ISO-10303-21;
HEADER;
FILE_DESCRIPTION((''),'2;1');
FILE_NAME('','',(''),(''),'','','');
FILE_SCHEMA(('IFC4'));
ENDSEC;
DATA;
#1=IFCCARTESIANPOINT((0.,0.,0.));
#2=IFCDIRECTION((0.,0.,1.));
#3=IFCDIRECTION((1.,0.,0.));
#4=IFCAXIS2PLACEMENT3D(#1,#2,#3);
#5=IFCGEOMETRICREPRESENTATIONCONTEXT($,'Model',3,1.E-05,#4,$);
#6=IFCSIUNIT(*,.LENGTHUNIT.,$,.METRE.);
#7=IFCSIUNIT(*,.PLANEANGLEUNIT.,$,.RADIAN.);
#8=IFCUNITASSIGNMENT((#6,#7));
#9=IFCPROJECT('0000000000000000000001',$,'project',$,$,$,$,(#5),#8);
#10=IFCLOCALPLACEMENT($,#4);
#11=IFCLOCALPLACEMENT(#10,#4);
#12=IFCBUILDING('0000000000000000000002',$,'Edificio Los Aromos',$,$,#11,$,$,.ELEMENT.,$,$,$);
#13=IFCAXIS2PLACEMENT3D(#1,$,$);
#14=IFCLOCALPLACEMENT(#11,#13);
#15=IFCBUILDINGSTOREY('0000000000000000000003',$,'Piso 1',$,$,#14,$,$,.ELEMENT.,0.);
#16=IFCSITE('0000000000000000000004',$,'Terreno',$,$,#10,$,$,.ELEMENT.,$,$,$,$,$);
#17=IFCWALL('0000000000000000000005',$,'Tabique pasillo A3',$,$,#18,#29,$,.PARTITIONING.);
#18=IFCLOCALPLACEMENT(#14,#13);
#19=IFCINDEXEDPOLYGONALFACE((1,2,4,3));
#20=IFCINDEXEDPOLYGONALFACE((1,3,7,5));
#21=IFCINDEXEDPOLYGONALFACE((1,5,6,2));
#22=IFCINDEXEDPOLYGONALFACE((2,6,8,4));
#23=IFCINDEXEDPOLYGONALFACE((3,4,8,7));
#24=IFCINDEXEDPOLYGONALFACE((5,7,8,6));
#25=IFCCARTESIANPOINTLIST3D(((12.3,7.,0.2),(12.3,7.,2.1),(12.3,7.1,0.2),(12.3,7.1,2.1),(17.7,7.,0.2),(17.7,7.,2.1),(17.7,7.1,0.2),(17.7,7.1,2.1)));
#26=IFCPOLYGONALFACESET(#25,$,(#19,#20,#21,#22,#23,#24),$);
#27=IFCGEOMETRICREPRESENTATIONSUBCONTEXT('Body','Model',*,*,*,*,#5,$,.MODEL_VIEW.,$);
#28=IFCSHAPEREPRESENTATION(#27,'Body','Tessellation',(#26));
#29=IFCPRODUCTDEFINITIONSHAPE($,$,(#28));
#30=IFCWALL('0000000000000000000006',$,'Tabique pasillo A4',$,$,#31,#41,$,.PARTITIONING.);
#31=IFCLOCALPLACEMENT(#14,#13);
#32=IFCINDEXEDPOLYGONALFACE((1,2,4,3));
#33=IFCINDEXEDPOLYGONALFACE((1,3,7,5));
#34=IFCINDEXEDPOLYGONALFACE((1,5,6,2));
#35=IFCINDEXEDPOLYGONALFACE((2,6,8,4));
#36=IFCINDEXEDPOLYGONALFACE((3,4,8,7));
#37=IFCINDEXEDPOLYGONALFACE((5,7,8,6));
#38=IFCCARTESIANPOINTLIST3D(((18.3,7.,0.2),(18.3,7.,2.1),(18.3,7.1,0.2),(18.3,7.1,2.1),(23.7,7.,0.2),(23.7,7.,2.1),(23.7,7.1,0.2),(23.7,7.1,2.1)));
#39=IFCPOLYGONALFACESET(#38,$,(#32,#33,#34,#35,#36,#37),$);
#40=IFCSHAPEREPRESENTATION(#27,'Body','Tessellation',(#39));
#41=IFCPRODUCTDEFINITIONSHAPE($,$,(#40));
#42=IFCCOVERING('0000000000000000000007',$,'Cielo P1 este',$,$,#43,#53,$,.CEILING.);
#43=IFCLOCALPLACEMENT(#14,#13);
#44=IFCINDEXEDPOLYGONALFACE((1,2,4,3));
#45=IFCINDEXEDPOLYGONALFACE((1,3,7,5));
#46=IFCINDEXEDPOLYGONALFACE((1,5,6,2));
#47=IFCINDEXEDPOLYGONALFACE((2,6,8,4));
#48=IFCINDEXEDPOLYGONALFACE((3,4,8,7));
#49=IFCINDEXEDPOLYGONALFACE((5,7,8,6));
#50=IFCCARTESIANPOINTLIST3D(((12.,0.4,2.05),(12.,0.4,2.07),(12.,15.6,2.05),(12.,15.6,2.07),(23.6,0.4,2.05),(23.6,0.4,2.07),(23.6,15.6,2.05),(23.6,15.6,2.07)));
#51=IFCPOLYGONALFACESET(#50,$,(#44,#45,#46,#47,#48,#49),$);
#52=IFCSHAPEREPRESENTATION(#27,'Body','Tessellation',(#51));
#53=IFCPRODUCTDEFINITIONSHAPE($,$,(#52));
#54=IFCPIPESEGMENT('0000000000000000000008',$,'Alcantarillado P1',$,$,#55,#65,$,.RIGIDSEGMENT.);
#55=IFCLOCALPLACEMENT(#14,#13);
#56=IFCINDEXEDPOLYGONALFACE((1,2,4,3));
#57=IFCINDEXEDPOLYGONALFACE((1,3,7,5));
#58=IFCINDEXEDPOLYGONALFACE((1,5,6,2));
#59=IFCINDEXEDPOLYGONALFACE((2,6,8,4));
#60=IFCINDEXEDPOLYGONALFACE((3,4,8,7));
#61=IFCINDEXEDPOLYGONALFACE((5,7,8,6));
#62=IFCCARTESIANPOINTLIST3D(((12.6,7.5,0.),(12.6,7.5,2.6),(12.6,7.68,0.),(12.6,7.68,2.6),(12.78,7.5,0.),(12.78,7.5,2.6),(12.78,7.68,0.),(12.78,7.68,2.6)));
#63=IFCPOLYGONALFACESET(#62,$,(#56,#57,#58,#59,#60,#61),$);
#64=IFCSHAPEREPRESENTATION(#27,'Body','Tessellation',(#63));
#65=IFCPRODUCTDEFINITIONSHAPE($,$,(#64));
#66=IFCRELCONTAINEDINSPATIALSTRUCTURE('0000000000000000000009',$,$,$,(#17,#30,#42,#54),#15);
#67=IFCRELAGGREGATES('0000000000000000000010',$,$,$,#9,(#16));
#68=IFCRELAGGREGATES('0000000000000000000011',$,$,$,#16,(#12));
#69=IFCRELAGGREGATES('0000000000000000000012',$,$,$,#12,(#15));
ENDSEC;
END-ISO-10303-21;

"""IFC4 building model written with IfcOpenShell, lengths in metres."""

from ifc_helpers import new_model, si_unit, frame, frame_2d, origin, origin_with_axes, place, context, subcontext, project, spatial, rectangle, extrude, element, save


model = new_model("IFC4")

# Units and contexts
model_context = context("Model", 3, precision=1e-05, world=origin_with_axes())
body_context = subcontext(model_context, "Body", "Model", "MODEL_VIEW")
ifc_project = project(units=[si_unit("LENGTHUNIT", "METRE"), si_unit("PLANEANGLEUNIT", "RADIAN")], contexts=[model_context])

# Site, building, storey
site_placement = place(None, origin_with_axes())
site = spatial("IfcSite", under=ifc_project, at=site_placement, Name="Terreno", CompositionType="ELEMENT")
building_placement = place(site_placement, origin_with_axes())
building = spatial("IfcBuilding", under=site, at=building_placement, Name="Edificio Los Aromos", CompositionType="ELEMENT")
storey_placement = place(building_placement, origin())
storey = spatial("IfcBuildingStorey", under=building, at=storey_placement, Name="Piso 1", CompositionType="ELEMENT", Elevation=0.0)

# Walls
for number, where, name in (
    (1, (12.3, 7.0, 0.2), "Tabique pasillo A3"),
    (2, (18.3, 7.0, 0.2), "Tabique pasillo A4"),
):
    element("IfcWall", number, at=place(storey_placement, frame(where)), inside=storey, Name=name, PredefinedType="PARTITIONING", context=body_context, shape_type="SweptSolid", body=[
        extrude(rectangle(XDim=5.4, YDim=0.1, at=frame_2d((2.7, 0.05))), origin_with_axes(), (0.0, 0.0, 1.0), 1.9),
    ])

# Covering
covering_placement = place(storey_placement, frame((12.0, 0.4, 2.05)))
element("IfcCovering", 3, at=covering_placement, inside=storey, Name="Cielo P1 este", PredefinedType="CEILING", context=body_context, shape_type="SweptSolid", body=[
    extrude(rectangle(XDim=11.6, YDim=15.2, at=frame_2d((5.8, 7.6))), origin_with_axes(), (0.0, 0.0, 1.0), 0.02),
])

# Pipe segment
pipe_segment_placement = place(storey_placement, frame((12.6, 7.5, 0.0)))
element("IfcPipeSegment", 4, at=pipe_segment_placement, inside=storey, Name="Alcantarillado P1", PredefinedType="RIGIDSEGMENT", context=body_context, shape_type="SweptSolid", body=[
    extrude(rectangle(XDim=0.18, YDim=0.18, at=frame_2d((0.09, 0.09))), origin_with_axes(), (0.0, 0.0, 1.0), 2.6),
])

save(model, "model.ifc")
